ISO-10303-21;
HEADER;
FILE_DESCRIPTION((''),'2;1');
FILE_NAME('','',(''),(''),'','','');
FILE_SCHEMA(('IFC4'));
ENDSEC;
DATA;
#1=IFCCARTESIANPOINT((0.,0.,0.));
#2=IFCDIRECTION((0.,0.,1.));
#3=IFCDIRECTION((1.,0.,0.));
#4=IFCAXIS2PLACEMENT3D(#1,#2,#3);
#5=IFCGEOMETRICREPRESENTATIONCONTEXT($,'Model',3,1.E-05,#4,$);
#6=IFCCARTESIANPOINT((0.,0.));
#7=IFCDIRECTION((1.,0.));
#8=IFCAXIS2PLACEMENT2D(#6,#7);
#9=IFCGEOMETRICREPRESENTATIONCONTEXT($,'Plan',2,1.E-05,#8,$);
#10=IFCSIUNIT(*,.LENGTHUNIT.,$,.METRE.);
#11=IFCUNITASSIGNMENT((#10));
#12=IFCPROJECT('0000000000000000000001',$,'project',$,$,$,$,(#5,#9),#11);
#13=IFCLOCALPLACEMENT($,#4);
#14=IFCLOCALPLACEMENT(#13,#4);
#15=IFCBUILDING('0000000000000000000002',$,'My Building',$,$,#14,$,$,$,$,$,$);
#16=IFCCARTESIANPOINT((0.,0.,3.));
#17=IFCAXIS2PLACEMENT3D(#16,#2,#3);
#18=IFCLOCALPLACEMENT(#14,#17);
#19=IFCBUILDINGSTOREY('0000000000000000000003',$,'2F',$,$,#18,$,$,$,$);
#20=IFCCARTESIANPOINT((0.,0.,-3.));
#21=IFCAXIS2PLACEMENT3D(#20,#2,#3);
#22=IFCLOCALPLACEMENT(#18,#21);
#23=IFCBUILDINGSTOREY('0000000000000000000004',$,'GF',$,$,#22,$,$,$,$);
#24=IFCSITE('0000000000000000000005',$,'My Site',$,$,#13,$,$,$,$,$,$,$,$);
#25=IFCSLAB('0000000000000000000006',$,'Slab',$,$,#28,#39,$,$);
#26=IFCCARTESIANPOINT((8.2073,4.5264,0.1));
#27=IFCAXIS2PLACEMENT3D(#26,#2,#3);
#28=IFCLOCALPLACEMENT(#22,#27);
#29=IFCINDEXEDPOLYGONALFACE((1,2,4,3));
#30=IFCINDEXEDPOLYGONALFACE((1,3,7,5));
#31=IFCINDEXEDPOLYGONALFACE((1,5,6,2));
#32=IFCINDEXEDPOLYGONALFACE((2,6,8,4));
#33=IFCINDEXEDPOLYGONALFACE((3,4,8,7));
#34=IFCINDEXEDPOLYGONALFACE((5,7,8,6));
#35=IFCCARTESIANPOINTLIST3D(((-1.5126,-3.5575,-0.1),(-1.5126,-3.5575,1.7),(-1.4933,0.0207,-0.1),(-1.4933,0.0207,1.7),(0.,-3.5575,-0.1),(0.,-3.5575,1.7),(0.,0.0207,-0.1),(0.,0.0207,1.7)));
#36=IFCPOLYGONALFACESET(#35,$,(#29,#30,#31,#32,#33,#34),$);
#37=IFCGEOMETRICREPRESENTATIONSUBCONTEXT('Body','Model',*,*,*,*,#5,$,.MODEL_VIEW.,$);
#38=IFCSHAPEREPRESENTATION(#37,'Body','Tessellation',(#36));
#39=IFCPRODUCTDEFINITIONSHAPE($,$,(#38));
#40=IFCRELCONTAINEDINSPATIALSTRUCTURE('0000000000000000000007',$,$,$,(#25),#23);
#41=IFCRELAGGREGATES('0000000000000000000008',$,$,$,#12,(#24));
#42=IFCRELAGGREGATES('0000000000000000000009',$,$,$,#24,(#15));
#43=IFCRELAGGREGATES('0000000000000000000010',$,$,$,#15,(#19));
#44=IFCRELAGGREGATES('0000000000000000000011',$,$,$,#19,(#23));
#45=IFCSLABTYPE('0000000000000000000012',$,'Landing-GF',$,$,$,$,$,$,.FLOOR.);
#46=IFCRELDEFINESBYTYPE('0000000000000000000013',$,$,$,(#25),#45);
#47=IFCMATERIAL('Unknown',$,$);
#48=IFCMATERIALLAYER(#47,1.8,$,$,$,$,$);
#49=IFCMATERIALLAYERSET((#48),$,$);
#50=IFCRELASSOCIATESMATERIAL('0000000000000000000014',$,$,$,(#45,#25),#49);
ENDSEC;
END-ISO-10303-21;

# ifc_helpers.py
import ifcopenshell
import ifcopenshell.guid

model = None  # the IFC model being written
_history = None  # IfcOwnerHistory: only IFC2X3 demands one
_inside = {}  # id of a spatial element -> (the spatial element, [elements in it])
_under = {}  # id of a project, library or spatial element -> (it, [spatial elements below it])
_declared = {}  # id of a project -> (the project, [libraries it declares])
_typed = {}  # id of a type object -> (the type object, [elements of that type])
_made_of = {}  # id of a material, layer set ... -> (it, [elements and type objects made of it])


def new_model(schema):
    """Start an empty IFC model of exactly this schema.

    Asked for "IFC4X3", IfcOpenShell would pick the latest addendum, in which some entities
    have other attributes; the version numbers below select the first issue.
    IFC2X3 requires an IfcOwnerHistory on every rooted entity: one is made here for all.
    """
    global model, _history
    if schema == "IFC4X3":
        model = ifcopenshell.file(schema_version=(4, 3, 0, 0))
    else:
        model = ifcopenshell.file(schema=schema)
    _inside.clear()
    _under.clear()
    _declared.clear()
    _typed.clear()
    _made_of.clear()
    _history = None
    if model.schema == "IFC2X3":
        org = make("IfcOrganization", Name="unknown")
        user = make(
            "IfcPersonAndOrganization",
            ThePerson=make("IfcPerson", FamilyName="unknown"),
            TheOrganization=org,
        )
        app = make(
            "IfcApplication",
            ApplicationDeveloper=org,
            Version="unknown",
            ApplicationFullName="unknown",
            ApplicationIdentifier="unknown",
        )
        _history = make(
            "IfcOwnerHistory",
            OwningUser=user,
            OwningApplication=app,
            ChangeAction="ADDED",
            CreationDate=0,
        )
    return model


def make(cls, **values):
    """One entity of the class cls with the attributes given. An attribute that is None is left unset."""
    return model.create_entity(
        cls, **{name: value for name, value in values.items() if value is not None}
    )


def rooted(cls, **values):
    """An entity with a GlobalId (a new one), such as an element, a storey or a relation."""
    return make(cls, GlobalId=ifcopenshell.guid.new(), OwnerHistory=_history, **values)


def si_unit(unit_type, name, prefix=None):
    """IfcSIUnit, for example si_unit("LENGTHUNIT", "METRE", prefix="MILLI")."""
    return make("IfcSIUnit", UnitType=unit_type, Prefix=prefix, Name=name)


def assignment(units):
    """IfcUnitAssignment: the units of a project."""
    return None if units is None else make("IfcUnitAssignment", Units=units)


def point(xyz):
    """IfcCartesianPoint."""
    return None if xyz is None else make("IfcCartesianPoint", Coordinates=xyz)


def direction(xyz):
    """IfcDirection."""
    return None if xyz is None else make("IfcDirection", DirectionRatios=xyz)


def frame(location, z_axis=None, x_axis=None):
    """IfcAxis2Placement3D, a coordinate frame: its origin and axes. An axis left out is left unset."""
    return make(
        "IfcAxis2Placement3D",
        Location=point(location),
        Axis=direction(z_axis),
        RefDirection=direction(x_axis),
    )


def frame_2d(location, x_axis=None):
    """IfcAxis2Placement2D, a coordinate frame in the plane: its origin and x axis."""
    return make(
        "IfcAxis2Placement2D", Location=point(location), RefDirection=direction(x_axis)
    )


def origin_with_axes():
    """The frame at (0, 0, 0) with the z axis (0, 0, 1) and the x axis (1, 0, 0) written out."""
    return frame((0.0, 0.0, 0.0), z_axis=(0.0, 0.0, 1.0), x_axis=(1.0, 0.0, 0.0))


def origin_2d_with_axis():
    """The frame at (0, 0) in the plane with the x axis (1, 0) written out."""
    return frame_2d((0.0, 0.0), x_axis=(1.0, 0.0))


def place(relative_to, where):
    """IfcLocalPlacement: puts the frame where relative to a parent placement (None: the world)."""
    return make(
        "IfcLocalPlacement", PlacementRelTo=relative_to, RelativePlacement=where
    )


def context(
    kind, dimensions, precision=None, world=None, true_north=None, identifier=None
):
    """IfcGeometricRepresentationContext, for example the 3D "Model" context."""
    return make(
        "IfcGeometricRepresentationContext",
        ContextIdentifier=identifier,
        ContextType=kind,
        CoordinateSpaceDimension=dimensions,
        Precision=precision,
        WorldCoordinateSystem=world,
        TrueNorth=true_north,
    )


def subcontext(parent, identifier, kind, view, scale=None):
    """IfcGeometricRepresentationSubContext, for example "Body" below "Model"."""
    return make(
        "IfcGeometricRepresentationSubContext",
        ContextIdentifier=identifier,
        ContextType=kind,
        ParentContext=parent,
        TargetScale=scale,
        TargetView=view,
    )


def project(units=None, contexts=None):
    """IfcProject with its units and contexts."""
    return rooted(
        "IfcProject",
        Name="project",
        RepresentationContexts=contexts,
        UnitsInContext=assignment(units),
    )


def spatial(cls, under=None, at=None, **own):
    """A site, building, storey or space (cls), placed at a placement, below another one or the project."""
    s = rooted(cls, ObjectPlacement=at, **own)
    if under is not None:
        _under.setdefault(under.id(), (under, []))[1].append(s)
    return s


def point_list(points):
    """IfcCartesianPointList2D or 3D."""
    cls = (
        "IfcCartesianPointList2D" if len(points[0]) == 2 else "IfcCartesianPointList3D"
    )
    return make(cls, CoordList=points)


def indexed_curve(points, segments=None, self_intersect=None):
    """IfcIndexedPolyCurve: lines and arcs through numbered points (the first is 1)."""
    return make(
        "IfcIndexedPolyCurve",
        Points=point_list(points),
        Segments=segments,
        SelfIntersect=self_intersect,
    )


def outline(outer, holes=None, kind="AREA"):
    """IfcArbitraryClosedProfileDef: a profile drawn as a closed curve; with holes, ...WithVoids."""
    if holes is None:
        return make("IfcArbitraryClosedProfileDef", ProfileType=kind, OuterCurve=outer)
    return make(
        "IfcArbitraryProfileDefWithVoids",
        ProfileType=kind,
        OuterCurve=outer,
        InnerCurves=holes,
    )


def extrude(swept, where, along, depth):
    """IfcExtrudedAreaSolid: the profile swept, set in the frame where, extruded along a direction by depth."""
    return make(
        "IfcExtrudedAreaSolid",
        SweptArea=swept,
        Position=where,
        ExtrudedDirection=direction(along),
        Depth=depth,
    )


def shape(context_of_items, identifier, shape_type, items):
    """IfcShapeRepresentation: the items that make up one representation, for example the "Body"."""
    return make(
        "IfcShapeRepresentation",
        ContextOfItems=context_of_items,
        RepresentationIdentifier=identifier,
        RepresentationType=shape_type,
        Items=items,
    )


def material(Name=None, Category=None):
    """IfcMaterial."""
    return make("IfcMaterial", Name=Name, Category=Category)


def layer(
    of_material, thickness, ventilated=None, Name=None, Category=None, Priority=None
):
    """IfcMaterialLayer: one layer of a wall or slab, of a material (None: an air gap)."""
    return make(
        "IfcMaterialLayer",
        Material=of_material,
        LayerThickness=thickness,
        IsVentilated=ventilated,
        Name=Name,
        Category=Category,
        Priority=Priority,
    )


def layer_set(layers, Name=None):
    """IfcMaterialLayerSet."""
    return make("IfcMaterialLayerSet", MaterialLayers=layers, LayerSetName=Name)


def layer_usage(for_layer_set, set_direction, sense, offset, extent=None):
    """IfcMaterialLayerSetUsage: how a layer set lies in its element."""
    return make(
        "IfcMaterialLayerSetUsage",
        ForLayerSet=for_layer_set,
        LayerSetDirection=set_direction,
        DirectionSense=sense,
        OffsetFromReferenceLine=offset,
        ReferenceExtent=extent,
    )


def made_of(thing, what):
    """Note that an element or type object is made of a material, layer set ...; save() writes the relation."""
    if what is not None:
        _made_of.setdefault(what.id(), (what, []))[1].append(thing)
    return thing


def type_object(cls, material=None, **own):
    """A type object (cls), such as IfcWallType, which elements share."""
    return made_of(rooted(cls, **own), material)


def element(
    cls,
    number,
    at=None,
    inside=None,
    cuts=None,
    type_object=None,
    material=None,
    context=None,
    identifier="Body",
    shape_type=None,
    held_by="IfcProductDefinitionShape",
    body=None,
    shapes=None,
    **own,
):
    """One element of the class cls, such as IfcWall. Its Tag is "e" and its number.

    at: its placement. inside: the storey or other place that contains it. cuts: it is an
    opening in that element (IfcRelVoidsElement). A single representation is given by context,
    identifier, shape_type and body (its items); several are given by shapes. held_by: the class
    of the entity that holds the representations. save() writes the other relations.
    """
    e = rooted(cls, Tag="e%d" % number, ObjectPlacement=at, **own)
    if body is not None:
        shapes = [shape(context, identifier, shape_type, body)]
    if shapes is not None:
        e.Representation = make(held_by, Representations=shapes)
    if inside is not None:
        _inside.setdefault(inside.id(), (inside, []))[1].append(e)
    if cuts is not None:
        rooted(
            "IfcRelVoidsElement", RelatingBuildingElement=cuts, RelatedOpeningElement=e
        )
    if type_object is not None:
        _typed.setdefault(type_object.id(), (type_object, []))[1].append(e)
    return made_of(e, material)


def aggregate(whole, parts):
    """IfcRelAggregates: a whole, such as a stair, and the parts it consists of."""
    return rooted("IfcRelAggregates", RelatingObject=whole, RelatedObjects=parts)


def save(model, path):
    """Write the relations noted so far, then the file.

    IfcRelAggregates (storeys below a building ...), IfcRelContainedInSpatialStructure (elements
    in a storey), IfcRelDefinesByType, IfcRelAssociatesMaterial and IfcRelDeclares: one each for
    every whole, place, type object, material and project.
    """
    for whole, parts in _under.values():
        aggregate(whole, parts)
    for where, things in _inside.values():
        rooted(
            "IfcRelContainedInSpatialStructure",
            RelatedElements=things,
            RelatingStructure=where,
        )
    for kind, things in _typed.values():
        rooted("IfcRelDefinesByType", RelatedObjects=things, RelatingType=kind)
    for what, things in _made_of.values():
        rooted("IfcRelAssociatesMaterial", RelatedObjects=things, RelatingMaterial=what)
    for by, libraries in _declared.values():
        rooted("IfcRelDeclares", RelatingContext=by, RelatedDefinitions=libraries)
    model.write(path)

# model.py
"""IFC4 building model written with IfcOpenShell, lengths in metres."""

from ifc_helpers import new_model, si_unit, frame, origin_with_axes, origin_2d_with_axis, place, context, subcontext, project, spatial, indexed_curve, outline, extrude, material, layer, layer_set, layer_usage, type_object, element, save


model = new_model("IFC4")

# Units and contexts
model_context = context("Model", 3, precision=1e-05, world=origin_with_axes())
plan_context = context("Plan", 2, precision=1e-05, world=origin_2d_with_axis())
body_context_1 = subcontext(model_context, "Body", "Model", "MODEL_VIEW")
ifc_project = project(units=[si_unit("LENGTHUNIT", "METRE")], contexts=[model_context, plan_context])

# Site, building, storeys
site_placement = place(None, origin_with_axes())
site = spatial("IfcSite", under=ifc_project, at=site_placement, Name="My Site")
building_placement = place(site_placement, origin_with_axes())
building = spatial("IfcBuilding", under=site, at=building_placement, Name="My Building")
storey_1_placement = place(building_placement, frame((0.0, 0.0, 3.0), z_axis=(0.0, 0.0, 1.0), x_axis=(1.0, 0.0, 0.0)))
storey_1 = spatial("IfcBuildingStorey", under=building, at=storey_1_placement, Name="2F")
storey_2_placement = place(storey_1_placement, frame((0.0, 0.0, -3.0), z_axis=(0.0, 0.0, 1.0), x_axis=(1.0, 0.0, 0.0)))
storey_2 = spatial("IfcBuildingStorey", under=storey_1, at=storey_2_placement, Name="GF")

# Slab
ifc_material = material(Name="Unknown")
ifc_layer_1 = layer(ifc_material, 1.8)
ifc_layer_set_1 = layer_set([ifc_layer_1])
ifc_layer_usage_1 = layer_usage(ifc_layer_set_1, "AXIS3", "POSITIVE", -0.1)
slab_type = type_object("IfcSlabType", Name="Landing-GF", PredefinedType="FLOOR", material=ifc_layer_set_1)
slab_1_placement = place(storey_2_placement, frame((8.2073, 4.5264, 0.1), z_axis=(0.0, 0.0, 1.0), x_axis=(1.0, 0.0, 0.0)))
element("IfcSlab", 1, at=slab_1_placement, inside=storey_2, type_object=slab_type, material=ifc_layer_usage_1, Name="Slab", context=body_context_1, shape_type="SweptSolid", body=[
    extrude(outline(indexed_curve([(0.0, 0.0207), (0.0, -3.5575), (-1.5126, -3.5575), (-1.4933, 0.0207), (0.0, 0.0207)])), frame((0.0, 0.0, -0.1), z_axis=(0.0, 0.0, 1.0), x_axis=(1.0, 0.0, 0.0)), (0.0, 0.0, 1.0), 1.8),
])

save(model, "model.ifc")
